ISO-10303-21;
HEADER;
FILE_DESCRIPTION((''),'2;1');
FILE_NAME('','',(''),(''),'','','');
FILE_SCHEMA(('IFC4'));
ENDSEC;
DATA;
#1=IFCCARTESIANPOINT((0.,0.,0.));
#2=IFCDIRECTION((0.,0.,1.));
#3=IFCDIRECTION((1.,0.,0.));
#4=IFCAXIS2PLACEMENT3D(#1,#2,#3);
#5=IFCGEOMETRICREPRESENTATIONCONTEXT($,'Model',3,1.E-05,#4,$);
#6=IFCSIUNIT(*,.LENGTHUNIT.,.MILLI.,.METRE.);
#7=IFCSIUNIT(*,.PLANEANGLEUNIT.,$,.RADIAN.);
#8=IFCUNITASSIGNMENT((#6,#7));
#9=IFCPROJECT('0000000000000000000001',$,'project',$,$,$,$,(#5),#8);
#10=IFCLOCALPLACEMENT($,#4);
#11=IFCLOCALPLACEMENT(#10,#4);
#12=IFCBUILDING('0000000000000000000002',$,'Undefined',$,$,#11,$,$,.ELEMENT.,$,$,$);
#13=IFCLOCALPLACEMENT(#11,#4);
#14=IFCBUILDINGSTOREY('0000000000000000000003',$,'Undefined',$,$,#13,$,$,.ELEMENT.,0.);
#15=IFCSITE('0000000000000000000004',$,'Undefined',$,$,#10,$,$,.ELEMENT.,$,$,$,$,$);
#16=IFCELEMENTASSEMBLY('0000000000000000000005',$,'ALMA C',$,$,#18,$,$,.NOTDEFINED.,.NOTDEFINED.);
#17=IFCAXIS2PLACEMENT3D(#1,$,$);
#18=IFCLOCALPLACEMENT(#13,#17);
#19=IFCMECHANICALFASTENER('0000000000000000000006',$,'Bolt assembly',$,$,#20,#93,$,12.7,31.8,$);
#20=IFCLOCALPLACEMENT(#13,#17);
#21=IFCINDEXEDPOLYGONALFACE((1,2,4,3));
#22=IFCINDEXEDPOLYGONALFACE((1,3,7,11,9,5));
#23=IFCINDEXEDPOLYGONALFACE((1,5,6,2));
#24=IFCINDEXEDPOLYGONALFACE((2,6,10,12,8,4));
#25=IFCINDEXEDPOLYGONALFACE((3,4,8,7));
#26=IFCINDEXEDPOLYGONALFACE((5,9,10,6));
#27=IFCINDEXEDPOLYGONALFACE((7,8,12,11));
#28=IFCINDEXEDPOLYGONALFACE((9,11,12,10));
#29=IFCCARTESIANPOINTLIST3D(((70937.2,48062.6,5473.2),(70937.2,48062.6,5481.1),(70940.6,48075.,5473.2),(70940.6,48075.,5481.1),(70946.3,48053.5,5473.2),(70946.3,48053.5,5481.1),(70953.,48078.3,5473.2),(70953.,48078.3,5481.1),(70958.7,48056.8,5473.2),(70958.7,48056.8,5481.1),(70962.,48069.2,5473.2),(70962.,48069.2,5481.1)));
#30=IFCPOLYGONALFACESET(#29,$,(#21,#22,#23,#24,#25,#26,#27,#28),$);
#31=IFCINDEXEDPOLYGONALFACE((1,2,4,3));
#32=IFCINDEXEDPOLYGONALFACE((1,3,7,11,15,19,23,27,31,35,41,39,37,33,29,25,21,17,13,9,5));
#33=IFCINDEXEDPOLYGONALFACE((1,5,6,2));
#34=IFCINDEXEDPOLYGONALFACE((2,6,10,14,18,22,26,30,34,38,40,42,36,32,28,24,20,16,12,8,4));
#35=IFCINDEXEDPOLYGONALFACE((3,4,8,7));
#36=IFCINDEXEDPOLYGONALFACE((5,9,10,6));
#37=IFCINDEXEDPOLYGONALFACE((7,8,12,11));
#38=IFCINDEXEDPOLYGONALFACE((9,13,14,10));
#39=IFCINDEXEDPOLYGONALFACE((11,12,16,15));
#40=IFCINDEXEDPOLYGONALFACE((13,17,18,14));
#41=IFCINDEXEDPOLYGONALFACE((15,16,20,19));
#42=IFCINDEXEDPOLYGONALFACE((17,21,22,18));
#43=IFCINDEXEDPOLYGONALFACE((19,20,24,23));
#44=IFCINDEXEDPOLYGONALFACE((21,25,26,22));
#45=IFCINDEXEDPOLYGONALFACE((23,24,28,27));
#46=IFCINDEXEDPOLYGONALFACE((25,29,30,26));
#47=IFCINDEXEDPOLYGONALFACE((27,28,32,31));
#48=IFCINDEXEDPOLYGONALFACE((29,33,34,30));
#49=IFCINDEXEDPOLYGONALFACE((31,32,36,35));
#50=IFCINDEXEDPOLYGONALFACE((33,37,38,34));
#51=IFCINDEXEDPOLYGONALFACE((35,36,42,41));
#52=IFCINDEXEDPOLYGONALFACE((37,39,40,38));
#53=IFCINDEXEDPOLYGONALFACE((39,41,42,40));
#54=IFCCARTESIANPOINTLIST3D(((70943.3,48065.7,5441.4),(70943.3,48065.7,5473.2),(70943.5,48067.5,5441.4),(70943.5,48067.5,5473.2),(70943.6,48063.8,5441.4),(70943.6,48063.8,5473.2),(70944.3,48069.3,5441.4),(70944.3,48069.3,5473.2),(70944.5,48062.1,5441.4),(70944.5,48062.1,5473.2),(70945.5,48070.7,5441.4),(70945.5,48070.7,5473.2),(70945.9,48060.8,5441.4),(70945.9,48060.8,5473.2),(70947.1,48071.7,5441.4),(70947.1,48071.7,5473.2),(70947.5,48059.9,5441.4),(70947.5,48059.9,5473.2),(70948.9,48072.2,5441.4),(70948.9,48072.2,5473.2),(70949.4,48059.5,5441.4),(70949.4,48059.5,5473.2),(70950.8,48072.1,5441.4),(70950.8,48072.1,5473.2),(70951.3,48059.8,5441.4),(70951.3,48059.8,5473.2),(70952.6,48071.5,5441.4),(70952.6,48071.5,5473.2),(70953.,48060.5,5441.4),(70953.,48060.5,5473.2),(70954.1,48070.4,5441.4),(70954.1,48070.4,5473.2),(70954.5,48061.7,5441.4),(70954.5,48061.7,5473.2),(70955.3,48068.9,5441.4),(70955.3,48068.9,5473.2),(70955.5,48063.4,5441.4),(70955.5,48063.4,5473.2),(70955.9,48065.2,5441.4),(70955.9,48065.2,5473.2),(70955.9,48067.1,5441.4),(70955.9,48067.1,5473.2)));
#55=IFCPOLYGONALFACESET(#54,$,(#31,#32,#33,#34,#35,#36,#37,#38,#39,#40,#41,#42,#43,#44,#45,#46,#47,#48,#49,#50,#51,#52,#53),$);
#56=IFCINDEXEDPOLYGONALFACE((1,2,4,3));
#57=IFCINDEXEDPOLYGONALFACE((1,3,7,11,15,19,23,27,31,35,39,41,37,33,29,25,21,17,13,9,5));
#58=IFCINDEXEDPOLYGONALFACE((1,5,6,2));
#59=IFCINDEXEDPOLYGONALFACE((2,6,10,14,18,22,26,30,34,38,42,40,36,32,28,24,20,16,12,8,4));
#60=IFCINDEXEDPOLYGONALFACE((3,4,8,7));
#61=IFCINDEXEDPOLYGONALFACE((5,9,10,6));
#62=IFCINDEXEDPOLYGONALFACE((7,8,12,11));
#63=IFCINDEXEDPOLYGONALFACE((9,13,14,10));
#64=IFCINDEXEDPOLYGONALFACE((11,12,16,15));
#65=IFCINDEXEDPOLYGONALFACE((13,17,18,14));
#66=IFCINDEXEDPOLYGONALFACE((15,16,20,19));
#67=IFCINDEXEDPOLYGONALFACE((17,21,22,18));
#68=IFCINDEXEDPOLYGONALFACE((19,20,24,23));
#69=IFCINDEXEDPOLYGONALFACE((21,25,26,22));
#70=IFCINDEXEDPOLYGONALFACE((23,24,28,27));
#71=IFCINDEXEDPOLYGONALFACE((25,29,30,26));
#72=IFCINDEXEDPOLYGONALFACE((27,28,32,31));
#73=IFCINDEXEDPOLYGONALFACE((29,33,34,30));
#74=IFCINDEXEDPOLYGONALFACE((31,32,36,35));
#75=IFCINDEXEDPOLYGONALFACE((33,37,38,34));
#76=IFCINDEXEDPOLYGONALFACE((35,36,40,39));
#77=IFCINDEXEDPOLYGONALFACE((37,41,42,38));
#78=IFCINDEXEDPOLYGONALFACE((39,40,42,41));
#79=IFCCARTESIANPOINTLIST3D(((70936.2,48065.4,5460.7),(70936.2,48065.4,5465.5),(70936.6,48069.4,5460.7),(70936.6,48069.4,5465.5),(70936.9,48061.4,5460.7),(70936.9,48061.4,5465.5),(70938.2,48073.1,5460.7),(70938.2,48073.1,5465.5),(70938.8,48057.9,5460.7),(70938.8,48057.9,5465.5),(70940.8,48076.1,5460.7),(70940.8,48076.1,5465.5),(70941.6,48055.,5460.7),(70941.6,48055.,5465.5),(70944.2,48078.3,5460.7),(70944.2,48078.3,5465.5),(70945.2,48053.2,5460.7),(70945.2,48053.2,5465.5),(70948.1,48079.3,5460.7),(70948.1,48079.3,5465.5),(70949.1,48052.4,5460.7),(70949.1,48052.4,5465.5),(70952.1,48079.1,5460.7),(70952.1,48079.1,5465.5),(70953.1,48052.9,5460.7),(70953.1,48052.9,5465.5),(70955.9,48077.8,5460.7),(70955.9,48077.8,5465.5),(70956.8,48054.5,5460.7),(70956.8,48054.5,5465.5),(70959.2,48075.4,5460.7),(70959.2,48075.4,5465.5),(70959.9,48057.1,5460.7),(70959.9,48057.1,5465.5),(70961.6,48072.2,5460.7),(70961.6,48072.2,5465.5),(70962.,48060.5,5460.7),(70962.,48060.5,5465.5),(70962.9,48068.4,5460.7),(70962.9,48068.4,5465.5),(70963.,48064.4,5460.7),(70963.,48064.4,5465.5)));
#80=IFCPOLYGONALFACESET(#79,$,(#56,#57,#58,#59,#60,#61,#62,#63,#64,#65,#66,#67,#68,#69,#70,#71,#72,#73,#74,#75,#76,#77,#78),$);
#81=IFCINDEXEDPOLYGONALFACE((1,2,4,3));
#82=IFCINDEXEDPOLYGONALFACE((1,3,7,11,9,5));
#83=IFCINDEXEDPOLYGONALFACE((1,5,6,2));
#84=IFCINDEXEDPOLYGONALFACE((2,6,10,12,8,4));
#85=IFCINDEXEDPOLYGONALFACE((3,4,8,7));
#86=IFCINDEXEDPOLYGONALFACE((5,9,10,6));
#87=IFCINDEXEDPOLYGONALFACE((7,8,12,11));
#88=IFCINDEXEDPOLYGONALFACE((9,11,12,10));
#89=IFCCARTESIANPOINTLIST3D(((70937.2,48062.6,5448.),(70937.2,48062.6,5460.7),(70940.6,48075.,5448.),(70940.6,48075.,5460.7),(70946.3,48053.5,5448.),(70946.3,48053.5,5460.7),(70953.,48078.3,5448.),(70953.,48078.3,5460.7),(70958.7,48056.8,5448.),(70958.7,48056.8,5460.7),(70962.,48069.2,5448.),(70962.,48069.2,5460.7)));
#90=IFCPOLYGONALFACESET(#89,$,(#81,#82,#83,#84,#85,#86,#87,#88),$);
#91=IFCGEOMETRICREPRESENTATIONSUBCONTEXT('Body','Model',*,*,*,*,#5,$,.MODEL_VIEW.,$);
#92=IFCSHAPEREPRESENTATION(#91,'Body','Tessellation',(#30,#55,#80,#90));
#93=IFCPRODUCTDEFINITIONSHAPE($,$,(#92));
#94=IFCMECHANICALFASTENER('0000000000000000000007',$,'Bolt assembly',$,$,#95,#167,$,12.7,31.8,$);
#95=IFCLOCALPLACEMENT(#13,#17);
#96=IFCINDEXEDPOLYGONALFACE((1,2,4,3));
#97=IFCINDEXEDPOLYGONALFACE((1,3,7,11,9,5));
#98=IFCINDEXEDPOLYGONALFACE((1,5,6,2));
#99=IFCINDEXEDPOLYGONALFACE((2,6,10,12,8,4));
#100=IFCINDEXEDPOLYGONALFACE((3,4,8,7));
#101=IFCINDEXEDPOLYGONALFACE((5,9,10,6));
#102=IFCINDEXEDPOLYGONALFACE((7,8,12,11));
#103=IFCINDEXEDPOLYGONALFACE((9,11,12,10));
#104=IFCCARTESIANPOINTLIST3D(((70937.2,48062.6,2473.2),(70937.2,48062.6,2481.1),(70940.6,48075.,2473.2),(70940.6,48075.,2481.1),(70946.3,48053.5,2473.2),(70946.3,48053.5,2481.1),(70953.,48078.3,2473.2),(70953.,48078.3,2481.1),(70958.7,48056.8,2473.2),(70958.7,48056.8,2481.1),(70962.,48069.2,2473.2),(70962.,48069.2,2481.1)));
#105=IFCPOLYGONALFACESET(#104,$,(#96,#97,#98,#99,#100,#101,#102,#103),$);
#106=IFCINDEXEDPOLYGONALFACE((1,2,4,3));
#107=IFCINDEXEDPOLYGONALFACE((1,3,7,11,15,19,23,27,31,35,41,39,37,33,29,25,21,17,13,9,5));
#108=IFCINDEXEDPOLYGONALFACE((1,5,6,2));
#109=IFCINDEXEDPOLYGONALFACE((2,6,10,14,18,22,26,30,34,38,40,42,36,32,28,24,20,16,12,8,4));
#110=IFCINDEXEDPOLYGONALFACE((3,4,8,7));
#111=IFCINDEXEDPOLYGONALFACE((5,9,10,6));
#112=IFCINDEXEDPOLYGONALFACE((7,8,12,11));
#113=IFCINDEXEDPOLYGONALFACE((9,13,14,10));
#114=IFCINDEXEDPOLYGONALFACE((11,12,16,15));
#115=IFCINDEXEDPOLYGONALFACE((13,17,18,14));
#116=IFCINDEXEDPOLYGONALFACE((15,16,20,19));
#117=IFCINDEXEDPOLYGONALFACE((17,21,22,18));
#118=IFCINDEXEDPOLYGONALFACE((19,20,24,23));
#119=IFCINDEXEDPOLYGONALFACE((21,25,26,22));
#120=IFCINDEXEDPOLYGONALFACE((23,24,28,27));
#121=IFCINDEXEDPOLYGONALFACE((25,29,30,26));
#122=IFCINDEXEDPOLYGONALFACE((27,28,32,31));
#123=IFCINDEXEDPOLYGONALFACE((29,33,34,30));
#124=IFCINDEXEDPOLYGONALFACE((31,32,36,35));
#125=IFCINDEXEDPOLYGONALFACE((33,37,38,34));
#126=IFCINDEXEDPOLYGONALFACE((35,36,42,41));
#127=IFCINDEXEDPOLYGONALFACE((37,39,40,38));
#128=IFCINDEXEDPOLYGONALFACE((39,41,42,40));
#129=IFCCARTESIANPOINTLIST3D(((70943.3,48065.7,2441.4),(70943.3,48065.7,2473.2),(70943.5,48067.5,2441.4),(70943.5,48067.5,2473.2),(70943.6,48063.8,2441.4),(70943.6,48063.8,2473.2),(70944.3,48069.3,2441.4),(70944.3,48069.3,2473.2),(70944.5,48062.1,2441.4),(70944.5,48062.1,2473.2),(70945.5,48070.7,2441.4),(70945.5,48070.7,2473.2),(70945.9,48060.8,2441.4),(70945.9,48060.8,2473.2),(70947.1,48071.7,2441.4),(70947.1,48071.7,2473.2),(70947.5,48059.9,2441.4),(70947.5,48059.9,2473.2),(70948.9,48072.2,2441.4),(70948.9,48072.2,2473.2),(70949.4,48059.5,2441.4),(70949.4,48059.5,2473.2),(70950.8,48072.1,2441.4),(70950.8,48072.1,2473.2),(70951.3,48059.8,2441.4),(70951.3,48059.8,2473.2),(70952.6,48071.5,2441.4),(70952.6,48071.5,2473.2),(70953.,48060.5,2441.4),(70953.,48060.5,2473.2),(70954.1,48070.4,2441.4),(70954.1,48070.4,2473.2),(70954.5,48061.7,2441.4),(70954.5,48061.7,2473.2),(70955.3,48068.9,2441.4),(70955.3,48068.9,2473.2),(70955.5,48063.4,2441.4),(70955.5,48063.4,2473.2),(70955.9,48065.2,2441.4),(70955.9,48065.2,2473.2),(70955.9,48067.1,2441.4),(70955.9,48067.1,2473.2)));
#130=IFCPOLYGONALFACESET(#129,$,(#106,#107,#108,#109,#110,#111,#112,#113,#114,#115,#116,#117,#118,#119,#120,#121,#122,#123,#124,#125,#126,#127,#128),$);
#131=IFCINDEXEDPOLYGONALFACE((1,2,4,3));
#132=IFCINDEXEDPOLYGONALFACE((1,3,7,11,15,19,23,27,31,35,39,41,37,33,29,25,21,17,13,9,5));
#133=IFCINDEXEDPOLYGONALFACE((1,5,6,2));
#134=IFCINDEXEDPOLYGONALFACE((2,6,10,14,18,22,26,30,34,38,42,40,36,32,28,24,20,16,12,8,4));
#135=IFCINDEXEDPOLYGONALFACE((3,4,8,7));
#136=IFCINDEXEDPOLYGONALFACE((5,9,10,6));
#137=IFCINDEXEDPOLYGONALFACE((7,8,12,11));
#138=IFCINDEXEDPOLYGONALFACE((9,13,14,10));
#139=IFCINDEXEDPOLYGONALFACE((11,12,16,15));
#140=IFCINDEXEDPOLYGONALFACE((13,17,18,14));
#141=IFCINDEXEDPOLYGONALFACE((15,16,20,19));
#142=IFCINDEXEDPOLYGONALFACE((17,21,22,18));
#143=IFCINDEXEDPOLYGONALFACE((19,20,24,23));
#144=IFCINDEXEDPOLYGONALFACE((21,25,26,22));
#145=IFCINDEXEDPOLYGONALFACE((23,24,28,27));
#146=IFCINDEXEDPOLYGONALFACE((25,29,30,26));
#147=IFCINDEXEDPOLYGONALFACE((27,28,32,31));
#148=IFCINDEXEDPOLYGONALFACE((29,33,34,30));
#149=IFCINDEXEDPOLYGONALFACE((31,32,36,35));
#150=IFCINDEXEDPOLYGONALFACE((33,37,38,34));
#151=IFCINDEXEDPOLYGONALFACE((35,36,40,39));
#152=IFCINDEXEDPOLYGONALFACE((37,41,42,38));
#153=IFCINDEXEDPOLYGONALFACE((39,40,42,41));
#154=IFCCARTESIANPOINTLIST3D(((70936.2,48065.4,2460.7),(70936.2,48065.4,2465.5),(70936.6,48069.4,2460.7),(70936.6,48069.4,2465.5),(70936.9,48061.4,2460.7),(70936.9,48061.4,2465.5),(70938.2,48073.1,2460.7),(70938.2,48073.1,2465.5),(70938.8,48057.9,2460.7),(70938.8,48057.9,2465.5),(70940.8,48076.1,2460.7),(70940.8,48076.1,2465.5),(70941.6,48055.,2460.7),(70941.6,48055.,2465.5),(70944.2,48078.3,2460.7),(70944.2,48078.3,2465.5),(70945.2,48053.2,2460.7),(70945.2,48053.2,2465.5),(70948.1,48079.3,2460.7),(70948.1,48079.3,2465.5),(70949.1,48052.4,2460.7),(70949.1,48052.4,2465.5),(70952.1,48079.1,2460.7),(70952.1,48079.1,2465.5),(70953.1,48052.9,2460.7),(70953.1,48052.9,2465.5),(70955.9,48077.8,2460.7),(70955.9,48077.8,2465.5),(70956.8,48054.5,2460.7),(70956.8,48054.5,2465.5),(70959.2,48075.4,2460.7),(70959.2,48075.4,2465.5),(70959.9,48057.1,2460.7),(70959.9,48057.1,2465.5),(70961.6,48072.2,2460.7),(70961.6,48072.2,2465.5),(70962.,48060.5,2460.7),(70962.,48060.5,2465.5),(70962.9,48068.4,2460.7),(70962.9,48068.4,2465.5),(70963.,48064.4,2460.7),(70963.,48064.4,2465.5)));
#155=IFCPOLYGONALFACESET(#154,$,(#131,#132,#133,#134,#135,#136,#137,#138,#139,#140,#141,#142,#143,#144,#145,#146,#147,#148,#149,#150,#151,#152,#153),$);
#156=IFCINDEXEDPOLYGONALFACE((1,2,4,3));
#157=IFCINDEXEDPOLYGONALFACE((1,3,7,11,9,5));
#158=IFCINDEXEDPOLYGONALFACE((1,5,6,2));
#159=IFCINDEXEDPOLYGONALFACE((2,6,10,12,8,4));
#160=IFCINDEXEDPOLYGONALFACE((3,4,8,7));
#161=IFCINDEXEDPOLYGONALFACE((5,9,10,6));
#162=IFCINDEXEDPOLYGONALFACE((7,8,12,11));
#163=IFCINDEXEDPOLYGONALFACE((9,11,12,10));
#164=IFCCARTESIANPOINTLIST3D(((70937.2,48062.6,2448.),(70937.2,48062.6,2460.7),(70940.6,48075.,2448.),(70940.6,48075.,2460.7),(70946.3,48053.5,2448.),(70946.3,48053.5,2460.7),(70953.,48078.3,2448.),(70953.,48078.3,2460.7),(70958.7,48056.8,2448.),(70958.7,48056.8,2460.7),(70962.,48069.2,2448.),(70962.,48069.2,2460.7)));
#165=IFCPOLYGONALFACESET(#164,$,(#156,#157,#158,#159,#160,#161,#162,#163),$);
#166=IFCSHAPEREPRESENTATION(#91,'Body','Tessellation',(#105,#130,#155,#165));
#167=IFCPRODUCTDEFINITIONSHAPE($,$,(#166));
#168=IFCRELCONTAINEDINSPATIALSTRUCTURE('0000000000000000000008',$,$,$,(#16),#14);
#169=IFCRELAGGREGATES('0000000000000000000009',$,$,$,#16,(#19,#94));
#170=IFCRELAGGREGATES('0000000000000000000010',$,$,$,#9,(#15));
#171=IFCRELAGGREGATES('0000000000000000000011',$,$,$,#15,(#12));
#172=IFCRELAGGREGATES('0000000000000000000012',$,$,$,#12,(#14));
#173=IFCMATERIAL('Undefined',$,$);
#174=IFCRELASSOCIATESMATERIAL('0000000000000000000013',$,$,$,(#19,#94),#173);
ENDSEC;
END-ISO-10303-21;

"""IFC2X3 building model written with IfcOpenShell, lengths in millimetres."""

from ifc_helpers import new_model, si_unit, frame, origin_with_axes, origin_2d_with_axis, place, context, subcontext, project, spatial, polyline, circle, outline, extrude, source, transform, mapped, material, element, aggregate, save


model = new_model("IFC2X3")

# Units and contexts
model_context = context("Model", 3, precision=1e-05, world=origin_with_axes())
body_context = subcontext(model_context, "Body", "Model", "MODEL_VIEW")
ifc_project = project(units=[si_unit("LENGTHUNIT", "METRE", prefix="MILLI"), si_unit("PLANEANGLEUNIT", "RADIAN")], contexts=[model_context])

# Site, building, storey
site_placement = place(None, origin_with_axes())
site = spatial("IfcSite", under=ifc_project, at=site_placement, Name="Undefined", CompositionType="ELEMENT")
building_placement = place(site_placement, origin_with_axes())
building = spatial("IfcBuilding", under=site, at=building_placement, Name="Undefined", CompositionType="ELEMENT")
storey_placement = place(building_placement, origin_with_axes())
storey = spatial("IfcBuildingStorey", under=building, at=storey_placement, Name="Undefined", CompositionType="ELEMENT", Elevation=0.0)

# Element assembly
assembly_1_placement = place(storey_placement, origin_with_axes())
assembly_1 = element("IfcElementAssembly", 1, at=assembly_1_placement, inside=storey, Name="ALMA C", AssemblyPlace="NOTDEFINED", PredefinedType="NOTDEFINED")

# Mechanical fasteners
ifc_material_1 = material(Name="Undefined")
shared_shape_1 = source(origin_with_axes(), body_context, "Body", "SweptSolid", [
    extrude(outline(polyline([(11.1, -6.4), (11.1, 6.4), (0.0, 12.8), (-11.1, 6.4), (-11.1, -6.4), (0.0, -12.8), (11.1, -6.4)])), frame((0.0, -11.1, 0.0), z_axis=(0.0, 1.0, 0.0), x_axis=(1.0, 0.0, 0.0)), (0.0, 0.0, 1.0), 7.9),
    extrude(circle(Radius=6.3, at=origin_2d_with_axis()), frame((0.0, -3.2, 0.0), z_axis=(0.0, 1.0, 0.0), x_axis=(1.0, 0.0, 0.0)), (0.0, 0.0, 1.0), 31.8),
    extrude(circle(Radius=13.5, at=origin_2d_with_axis()), frame((0.0, 4.5, 0.0), z_axis=(0.0, 1.0, 0.0), x_axis=(1.0, 0.0, 0.0)), (0.0, 0.0, 1.0), 4.8),
    extrude(outline(polyline([(11.1, -6.4), (11.1, 6.4), (0.0, 12.8), (-11.1, 6.4), (-11.1, -6.4), (0.0, -12.8), (11.1, -6.4)])), frame((0.0, 9.3, 0.0), z_axis=(0.0, 1.0, 0.0), x_axis=(1.0, 0.0, 0.0)), (0.0, 0.0, 1.0), 12.7),
])
mechanical_fastener_1_placement = place(assembly_1_placement, frame((70949.6, 48065.9, 5470.0), z_axis=(-0.707107, 0.707107, 0.0), x_axis=(0.707107, 0.707107, 0.0)))
mechanical_fastener_1 = element("IfcMechanicalFastener", 2, at=mechanical_fastener_1_placement, material=ifc_material_1, Name="Bolt assembly", NominalDiameter=12.7, NominalLength=31.8, context=body_context, shape_type="MappedRepresentation", body=[
    mapped(shared_shape_1, transform((0.0, 0.0, 0.0))),
])
mechanical_fastener_2_placement = place(assembly_1_placement, frame((70949.6, 48065.9, 2470.0), z_axis=(-0.707107, 0.707107, 0.0), x_axis=(0.707107, 0.707107, 0.0)))
mechanical_fastener_2 = element("IfcMechanicalFastener", 3, at=mechanical_fastener_2_placement, material=ifc_material_1, Name="Bolt assembly", NominalDiameter=12.7, NominalLength=31.8, context=body_context, shape_type="MappedRepresentation", body=[
    mapped(shared_shape_1, transform((0.0, 0.0, 0.0))),
])
aggregate(assembly_1, [mechanical_fastener_1, mechanical_fastener_2])

save(model, "model.ifc")
